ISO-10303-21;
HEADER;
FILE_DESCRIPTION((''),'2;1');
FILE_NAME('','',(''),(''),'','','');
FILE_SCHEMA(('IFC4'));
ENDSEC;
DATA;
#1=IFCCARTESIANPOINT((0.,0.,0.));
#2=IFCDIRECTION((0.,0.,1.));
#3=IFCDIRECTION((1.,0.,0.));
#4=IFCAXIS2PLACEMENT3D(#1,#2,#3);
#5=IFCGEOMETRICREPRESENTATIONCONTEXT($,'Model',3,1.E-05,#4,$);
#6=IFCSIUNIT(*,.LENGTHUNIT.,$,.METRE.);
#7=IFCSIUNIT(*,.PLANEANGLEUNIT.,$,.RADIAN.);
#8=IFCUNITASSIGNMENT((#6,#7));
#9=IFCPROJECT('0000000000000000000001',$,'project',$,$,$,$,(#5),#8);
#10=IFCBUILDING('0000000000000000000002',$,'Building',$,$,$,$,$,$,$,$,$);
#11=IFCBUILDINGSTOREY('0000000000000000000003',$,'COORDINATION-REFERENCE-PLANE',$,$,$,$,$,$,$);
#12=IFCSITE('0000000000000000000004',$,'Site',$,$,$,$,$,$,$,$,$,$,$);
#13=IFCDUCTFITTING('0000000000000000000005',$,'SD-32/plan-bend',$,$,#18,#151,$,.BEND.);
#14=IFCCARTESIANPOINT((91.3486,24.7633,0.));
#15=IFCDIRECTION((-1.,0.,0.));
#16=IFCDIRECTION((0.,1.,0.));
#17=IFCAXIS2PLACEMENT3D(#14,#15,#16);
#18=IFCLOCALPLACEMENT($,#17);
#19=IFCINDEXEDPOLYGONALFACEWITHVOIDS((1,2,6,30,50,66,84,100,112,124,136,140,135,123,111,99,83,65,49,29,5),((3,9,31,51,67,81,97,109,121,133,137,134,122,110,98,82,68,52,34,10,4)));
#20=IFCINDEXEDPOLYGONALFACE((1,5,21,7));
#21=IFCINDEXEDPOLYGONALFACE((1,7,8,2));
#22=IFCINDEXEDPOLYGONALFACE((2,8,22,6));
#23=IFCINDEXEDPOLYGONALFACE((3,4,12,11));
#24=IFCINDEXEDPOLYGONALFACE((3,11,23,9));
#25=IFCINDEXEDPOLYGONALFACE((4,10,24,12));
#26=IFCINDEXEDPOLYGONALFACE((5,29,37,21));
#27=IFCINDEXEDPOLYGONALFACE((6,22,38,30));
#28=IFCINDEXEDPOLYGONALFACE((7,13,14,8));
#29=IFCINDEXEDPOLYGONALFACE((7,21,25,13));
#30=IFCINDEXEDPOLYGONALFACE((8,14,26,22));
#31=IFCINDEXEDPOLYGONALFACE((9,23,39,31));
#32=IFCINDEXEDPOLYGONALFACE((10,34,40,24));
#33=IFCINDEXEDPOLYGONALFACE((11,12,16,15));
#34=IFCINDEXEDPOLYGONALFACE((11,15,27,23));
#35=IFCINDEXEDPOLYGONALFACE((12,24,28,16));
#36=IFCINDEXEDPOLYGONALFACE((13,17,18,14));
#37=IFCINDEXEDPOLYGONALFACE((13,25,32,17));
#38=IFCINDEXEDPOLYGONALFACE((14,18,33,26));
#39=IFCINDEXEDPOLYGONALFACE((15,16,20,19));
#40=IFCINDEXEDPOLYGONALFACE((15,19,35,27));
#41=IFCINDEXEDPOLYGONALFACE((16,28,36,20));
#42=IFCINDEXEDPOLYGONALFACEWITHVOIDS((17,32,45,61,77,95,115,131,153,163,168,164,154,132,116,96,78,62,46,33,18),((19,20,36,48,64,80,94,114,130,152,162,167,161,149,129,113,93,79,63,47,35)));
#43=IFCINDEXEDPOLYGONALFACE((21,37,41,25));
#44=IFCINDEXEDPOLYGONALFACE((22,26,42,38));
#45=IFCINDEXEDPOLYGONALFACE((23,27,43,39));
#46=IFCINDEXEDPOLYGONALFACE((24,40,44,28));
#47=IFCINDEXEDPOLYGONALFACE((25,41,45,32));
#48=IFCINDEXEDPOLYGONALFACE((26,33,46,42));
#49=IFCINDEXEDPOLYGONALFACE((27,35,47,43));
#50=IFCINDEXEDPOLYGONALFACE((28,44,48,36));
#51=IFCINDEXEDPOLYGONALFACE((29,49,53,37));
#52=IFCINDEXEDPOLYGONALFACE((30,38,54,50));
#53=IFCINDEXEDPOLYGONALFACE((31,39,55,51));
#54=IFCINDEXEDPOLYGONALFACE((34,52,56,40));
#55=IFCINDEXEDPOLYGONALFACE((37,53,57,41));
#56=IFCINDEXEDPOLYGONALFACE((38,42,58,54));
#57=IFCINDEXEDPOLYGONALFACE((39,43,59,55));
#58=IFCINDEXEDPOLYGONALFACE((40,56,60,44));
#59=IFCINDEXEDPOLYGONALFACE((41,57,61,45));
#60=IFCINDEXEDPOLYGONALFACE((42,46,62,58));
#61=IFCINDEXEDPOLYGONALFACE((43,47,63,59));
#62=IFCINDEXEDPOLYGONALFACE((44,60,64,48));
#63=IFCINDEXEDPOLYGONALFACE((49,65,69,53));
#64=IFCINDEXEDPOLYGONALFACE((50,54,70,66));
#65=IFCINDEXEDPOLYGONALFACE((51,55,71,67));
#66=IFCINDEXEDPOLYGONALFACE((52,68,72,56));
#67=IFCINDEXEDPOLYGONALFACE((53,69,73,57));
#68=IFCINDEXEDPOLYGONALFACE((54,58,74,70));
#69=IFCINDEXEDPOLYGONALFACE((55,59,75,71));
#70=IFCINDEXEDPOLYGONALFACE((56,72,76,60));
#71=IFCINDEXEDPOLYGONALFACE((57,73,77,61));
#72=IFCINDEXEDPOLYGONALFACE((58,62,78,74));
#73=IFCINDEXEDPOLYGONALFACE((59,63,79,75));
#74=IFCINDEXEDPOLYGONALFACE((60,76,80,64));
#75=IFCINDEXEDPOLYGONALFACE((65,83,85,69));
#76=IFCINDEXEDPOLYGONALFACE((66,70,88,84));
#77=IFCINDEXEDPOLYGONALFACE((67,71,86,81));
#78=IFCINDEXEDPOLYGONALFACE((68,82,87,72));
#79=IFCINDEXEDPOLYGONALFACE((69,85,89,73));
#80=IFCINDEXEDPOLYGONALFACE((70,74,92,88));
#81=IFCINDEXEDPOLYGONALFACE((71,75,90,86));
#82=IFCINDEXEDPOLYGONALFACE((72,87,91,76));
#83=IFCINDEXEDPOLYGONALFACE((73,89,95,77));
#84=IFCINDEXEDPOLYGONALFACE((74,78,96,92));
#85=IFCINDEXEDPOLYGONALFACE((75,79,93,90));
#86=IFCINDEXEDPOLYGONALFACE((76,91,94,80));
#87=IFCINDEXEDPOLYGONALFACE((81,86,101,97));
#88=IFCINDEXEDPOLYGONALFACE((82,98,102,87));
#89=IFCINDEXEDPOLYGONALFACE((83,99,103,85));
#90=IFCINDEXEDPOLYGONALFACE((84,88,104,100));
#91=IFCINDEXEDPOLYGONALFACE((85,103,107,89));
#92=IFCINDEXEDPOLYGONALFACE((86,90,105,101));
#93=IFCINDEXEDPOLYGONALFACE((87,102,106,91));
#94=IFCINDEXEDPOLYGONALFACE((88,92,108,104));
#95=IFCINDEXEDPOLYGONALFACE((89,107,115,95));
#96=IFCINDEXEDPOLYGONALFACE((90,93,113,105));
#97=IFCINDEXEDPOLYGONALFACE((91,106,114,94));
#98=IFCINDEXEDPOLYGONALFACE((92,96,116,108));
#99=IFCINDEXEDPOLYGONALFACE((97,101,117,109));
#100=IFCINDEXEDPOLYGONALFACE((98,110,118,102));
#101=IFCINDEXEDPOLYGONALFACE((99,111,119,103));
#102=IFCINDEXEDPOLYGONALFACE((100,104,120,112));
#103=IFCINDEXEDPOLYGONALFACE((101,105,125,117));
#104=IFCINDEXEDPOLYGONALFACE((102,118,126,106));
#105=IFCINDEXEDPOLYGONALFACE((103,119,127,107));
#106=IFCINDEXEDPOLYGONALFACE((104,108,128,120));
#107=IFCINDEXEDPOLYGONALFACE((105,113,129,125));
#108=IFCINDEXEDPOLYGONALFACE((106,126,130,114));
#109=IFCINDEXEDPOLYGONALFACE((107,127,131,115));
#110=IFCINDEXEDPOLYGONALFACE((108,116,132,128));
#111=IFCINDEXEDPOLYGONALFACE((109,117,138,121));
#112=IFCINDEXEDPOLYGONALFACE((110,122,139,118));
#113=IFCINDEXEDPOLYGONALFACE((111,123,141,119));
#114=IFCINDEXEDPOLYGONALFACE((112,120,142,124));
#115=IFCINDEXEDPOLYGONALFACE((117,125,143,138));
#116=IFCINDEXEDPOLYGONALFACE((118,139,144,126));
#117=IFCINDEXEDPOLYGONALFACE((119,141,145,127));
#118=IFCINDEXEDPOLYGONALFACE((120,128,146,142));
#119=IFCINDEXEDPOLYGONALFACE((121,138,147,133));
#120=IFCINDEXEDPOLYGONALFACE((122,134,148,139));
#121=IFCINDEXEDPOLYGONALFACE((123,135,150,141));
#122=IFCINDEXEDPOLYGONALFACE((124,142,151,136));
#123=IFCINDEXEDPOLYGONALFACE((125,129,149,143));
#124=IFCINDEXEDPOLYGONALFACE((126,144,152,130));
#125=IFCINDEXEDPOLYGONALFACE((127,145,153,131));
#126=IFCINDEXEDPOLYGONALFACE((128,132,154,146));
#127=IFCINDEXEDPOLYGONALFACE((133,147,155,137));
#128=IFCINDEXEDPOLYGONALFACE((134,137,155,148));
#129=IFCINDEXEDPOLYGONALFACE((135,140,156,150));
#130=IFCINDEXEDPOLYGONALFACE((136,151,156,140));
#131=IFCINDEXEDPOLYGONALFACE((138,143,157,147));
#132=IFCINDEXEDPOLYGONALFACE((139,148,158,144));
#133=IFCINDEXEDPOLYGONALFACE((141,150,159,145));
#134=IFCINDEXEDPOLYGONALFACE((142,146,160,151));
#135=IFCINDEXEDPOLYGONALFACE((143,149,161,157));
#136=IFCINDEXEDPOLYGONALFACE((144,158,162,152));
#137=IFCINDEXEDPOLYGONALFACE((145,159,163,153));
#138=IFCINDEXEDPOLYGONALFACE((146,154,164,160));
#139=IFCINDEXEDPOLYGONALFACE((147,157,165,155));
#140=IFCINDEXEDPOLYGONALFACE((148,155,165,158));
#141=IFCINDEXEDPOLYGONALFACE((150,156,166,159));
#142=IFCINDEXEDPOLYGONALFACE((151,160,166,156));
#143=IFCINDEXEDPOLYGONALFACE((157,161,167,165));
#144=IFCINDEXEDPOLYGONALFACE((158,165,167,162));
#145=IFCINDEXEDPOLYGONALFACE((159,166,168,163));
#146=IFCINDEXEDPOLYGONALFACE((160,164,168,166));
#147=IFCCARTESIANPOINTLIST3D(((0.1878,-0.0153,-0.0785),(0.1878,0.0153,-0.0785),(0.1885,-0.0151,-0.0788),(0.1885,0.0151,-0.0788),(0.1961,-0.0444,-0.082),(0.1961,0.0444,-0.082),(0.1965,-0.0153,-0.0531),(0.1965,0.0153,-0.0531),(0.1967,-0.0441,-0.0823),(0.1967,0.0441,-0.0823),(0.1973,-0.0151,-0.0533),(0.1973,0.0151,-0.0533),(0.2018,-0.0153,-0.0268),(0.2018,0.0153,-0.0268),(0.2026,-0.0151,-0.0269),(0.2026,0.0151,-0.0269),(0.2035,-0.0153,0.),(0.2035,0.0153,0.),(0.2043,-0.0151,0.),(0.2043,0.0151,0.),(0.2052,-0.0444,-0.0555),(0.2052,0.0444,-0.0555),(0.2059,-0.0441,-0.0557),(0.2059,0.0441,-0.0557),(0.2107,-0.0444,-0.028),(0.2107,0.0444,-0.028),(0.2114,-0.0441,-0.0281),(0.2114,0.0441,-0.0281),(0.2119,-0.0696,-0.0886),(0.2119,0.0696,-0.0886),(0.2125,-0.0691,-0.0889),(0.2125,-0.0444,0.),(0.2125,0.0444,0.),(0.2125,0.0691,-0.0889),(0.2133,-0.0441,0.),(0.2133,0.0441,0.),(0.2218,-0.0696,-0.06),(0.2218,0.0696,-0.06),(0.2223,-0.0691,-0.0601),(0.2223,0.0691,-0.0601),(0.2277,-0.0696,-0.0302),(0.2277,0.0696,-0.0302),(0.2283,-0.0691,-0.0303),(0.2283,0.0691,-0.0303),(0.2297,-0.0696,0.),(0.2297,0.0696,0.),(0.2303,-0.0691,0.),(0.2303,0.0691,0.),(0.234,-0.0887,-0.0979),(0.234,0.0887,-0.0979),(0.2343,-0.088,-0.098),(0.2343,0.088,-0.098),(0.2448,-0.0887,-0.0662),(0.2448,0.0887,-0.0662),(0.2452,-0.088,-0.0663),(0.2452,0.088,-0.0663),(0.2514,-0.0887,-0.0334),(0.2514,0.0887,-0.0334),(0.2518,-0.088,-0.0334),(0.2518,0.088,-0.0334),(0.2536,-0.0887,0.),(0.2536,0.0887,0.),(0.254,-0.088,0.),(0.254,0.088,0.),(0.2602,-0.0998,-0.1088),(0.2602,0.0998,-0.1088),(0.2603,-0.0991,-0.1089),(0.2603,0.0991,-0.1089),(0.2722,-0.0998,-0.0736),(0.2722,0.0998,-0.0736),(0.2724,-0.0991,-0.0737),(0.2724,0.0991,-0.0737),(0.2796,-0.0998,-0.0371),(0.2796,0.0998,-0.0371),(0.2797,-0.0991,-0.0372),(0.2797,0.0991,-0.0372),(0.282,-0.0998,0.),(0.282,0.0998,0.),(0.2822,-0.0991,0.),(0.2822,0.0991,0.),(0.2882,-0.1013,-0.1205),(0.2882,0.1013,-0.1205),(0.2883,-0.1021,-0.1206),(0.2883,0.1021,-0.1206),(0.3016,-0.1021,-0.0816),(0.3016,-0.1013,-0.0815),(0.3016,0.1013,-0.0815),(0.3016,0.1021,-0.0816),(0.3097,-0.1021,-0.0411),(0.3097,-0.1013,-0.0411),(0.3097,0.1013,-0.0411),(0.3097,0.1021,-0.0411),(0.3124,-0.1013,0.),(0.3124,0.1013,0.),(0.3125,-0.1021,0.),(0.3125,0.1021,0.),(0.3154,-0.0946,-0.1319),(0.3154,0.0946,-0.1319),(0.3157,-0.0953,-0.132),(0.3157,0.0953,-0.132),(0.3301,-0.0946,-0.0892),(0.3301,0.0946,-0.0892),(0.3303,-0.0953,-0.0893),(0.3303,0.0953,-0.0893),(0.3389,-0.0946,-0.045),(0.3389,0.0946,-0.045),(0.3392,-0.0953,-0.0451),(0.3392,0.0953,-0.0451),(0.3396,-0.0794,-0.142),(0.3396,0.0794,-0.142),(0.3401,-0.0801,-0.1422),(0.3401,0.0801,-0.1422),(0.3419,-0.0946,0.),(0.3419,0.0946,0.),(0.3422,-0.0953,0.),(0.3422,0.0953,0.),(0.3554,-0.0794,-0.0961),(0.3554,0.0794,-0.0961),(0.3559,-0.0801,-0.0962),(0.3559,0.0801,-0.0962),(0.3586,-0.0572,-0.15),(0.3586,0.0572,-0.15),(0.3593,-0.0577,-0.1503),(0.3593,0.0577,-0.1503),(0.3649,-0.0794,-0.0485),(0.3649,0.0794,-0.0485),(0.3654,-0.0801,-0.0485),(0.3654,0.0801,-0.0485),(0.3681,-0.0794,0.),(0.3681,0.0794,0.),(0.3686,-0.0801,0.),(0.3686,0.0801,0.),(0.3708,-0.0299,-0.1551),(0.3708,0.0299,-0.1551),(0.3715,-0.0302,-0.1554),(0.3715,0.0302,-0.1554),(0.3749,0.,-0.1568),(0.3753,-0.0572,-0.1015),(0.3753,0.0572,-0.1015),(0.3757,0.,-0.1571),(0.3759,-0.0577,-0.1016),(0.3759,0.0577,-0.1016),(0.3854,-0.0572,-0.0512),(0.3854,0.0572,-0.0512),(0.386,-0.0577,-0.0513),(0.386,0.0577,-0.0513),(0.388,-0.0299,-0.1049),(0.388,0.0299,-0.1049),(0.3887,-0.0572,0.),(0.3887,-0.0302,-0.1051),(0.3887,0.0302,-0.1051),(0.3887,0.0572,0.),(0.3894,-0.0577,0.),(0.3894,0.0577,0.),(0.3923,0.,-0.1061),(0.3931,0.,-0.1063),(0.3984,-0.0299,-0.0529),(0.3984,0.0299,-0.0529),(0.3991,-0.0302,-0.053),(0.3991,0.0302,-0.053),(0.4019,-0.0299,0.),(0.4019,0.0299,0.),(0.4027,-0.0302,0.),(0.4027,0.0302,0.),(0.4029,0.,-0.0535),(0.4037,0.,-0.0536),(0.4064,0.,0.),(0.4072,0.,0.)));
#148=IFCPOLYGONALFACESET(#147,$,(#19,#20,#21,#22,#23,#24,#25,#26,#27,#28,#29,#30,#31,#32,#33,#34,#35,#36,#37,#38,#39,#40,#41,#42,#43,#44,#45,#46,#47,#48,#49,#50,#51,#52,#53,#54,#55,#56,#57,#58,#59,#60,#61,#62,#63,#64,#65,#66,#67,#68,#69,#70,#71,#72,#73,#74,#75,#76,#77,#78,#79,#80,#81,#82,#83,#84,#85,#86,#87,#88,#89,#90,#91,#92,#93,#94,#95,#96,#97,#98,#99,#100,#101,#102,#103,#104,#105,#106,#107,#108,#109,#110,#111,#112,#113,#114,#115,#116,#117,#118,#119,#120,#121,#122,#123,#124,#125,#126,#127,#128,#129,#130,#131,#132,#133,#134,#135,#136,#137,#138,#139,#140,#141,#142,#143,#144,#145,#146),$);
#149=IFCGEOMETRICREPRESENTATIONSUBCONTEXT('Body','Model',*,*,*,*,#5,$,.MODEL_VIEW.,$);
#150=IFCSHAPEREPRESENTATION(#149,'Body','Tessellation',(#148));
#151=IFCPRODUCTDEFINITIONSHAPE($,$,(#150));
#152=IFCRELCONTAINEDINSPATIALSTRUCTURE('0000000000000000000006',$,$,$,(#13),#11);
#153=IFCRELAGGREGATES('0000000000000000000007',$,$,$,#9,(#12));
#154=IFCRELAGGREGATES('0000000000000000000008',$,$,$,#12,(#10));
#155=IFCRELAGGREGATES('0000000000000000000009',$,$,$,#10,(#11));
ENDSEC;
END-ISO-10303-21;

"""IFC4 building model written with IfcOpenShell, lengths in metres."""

from ifc_helpers import new_model, entity, si_unit, frame, origin_with_axes, place, context, subcontext, project, spatial, element, save


model = new_model("IFC4")

# Units and contexts
model_context = context("Model", 3, precision=1e-05, world=origin_with_axes())
body_context_1 = subcontext(model_context, "Body", "Model", "MODEL_VIEW")
ifc_project = project(units=[si_unit("LENGTHUNIT", "METRE"), si_unit("PLANEANGLEUNIT", "RADIAN")], contexts=[model_context])

# Site, building, storey
site = spatial("IfcSite", under=ifc_project, Name="Site")
building = spatial("IfcBuilding", under=site, Name="Building")
storey = spatial("IfcBuildingStorey", under=building, Name="COORDINATION-REFERENCE-PLANE")

# Duct fitting
duct_fitting_1_placement = place(None, frame((91.3486, 24.7633, 0.0), z_axis=(-1.0, 0.0, 0.0), x_axis=(0.0, 1.0, 0.0)))
element("IfcDuctFitting", 1, at=duct_fitting_1_placement, inside=storey, Name="SD-32/plan-bend", PredefinedType="BEND", context=body_context_1, shape_type="SweptSolid", body=[
    entity("IfcRevolvedAreaSolid", entity("IfcCircleHollowProfileDef", "AREA", None, entity("IfcAxis2Placement2D", entity("IfcCartesianPoint", [0.3048, 0.0])), 0.1024, 0.0008), entity("IfcAxis2Placement3D", entity("IfcCartesianPoint", [0.0, 0.0, 0.0]), entity("IfcDirection", [0.0, 0.0, 1.0]), entity("IfcDirection", [1.0, 0.0, 0.0])), entity("IfcAxis1Placement", entity("IfcCartesianPoint", [0.0, 0.0, 0.0]), entity("IfcDirection", [0.0, 1.0, 0.0])), 0.396124),
])

save(model, "model.ifc")
